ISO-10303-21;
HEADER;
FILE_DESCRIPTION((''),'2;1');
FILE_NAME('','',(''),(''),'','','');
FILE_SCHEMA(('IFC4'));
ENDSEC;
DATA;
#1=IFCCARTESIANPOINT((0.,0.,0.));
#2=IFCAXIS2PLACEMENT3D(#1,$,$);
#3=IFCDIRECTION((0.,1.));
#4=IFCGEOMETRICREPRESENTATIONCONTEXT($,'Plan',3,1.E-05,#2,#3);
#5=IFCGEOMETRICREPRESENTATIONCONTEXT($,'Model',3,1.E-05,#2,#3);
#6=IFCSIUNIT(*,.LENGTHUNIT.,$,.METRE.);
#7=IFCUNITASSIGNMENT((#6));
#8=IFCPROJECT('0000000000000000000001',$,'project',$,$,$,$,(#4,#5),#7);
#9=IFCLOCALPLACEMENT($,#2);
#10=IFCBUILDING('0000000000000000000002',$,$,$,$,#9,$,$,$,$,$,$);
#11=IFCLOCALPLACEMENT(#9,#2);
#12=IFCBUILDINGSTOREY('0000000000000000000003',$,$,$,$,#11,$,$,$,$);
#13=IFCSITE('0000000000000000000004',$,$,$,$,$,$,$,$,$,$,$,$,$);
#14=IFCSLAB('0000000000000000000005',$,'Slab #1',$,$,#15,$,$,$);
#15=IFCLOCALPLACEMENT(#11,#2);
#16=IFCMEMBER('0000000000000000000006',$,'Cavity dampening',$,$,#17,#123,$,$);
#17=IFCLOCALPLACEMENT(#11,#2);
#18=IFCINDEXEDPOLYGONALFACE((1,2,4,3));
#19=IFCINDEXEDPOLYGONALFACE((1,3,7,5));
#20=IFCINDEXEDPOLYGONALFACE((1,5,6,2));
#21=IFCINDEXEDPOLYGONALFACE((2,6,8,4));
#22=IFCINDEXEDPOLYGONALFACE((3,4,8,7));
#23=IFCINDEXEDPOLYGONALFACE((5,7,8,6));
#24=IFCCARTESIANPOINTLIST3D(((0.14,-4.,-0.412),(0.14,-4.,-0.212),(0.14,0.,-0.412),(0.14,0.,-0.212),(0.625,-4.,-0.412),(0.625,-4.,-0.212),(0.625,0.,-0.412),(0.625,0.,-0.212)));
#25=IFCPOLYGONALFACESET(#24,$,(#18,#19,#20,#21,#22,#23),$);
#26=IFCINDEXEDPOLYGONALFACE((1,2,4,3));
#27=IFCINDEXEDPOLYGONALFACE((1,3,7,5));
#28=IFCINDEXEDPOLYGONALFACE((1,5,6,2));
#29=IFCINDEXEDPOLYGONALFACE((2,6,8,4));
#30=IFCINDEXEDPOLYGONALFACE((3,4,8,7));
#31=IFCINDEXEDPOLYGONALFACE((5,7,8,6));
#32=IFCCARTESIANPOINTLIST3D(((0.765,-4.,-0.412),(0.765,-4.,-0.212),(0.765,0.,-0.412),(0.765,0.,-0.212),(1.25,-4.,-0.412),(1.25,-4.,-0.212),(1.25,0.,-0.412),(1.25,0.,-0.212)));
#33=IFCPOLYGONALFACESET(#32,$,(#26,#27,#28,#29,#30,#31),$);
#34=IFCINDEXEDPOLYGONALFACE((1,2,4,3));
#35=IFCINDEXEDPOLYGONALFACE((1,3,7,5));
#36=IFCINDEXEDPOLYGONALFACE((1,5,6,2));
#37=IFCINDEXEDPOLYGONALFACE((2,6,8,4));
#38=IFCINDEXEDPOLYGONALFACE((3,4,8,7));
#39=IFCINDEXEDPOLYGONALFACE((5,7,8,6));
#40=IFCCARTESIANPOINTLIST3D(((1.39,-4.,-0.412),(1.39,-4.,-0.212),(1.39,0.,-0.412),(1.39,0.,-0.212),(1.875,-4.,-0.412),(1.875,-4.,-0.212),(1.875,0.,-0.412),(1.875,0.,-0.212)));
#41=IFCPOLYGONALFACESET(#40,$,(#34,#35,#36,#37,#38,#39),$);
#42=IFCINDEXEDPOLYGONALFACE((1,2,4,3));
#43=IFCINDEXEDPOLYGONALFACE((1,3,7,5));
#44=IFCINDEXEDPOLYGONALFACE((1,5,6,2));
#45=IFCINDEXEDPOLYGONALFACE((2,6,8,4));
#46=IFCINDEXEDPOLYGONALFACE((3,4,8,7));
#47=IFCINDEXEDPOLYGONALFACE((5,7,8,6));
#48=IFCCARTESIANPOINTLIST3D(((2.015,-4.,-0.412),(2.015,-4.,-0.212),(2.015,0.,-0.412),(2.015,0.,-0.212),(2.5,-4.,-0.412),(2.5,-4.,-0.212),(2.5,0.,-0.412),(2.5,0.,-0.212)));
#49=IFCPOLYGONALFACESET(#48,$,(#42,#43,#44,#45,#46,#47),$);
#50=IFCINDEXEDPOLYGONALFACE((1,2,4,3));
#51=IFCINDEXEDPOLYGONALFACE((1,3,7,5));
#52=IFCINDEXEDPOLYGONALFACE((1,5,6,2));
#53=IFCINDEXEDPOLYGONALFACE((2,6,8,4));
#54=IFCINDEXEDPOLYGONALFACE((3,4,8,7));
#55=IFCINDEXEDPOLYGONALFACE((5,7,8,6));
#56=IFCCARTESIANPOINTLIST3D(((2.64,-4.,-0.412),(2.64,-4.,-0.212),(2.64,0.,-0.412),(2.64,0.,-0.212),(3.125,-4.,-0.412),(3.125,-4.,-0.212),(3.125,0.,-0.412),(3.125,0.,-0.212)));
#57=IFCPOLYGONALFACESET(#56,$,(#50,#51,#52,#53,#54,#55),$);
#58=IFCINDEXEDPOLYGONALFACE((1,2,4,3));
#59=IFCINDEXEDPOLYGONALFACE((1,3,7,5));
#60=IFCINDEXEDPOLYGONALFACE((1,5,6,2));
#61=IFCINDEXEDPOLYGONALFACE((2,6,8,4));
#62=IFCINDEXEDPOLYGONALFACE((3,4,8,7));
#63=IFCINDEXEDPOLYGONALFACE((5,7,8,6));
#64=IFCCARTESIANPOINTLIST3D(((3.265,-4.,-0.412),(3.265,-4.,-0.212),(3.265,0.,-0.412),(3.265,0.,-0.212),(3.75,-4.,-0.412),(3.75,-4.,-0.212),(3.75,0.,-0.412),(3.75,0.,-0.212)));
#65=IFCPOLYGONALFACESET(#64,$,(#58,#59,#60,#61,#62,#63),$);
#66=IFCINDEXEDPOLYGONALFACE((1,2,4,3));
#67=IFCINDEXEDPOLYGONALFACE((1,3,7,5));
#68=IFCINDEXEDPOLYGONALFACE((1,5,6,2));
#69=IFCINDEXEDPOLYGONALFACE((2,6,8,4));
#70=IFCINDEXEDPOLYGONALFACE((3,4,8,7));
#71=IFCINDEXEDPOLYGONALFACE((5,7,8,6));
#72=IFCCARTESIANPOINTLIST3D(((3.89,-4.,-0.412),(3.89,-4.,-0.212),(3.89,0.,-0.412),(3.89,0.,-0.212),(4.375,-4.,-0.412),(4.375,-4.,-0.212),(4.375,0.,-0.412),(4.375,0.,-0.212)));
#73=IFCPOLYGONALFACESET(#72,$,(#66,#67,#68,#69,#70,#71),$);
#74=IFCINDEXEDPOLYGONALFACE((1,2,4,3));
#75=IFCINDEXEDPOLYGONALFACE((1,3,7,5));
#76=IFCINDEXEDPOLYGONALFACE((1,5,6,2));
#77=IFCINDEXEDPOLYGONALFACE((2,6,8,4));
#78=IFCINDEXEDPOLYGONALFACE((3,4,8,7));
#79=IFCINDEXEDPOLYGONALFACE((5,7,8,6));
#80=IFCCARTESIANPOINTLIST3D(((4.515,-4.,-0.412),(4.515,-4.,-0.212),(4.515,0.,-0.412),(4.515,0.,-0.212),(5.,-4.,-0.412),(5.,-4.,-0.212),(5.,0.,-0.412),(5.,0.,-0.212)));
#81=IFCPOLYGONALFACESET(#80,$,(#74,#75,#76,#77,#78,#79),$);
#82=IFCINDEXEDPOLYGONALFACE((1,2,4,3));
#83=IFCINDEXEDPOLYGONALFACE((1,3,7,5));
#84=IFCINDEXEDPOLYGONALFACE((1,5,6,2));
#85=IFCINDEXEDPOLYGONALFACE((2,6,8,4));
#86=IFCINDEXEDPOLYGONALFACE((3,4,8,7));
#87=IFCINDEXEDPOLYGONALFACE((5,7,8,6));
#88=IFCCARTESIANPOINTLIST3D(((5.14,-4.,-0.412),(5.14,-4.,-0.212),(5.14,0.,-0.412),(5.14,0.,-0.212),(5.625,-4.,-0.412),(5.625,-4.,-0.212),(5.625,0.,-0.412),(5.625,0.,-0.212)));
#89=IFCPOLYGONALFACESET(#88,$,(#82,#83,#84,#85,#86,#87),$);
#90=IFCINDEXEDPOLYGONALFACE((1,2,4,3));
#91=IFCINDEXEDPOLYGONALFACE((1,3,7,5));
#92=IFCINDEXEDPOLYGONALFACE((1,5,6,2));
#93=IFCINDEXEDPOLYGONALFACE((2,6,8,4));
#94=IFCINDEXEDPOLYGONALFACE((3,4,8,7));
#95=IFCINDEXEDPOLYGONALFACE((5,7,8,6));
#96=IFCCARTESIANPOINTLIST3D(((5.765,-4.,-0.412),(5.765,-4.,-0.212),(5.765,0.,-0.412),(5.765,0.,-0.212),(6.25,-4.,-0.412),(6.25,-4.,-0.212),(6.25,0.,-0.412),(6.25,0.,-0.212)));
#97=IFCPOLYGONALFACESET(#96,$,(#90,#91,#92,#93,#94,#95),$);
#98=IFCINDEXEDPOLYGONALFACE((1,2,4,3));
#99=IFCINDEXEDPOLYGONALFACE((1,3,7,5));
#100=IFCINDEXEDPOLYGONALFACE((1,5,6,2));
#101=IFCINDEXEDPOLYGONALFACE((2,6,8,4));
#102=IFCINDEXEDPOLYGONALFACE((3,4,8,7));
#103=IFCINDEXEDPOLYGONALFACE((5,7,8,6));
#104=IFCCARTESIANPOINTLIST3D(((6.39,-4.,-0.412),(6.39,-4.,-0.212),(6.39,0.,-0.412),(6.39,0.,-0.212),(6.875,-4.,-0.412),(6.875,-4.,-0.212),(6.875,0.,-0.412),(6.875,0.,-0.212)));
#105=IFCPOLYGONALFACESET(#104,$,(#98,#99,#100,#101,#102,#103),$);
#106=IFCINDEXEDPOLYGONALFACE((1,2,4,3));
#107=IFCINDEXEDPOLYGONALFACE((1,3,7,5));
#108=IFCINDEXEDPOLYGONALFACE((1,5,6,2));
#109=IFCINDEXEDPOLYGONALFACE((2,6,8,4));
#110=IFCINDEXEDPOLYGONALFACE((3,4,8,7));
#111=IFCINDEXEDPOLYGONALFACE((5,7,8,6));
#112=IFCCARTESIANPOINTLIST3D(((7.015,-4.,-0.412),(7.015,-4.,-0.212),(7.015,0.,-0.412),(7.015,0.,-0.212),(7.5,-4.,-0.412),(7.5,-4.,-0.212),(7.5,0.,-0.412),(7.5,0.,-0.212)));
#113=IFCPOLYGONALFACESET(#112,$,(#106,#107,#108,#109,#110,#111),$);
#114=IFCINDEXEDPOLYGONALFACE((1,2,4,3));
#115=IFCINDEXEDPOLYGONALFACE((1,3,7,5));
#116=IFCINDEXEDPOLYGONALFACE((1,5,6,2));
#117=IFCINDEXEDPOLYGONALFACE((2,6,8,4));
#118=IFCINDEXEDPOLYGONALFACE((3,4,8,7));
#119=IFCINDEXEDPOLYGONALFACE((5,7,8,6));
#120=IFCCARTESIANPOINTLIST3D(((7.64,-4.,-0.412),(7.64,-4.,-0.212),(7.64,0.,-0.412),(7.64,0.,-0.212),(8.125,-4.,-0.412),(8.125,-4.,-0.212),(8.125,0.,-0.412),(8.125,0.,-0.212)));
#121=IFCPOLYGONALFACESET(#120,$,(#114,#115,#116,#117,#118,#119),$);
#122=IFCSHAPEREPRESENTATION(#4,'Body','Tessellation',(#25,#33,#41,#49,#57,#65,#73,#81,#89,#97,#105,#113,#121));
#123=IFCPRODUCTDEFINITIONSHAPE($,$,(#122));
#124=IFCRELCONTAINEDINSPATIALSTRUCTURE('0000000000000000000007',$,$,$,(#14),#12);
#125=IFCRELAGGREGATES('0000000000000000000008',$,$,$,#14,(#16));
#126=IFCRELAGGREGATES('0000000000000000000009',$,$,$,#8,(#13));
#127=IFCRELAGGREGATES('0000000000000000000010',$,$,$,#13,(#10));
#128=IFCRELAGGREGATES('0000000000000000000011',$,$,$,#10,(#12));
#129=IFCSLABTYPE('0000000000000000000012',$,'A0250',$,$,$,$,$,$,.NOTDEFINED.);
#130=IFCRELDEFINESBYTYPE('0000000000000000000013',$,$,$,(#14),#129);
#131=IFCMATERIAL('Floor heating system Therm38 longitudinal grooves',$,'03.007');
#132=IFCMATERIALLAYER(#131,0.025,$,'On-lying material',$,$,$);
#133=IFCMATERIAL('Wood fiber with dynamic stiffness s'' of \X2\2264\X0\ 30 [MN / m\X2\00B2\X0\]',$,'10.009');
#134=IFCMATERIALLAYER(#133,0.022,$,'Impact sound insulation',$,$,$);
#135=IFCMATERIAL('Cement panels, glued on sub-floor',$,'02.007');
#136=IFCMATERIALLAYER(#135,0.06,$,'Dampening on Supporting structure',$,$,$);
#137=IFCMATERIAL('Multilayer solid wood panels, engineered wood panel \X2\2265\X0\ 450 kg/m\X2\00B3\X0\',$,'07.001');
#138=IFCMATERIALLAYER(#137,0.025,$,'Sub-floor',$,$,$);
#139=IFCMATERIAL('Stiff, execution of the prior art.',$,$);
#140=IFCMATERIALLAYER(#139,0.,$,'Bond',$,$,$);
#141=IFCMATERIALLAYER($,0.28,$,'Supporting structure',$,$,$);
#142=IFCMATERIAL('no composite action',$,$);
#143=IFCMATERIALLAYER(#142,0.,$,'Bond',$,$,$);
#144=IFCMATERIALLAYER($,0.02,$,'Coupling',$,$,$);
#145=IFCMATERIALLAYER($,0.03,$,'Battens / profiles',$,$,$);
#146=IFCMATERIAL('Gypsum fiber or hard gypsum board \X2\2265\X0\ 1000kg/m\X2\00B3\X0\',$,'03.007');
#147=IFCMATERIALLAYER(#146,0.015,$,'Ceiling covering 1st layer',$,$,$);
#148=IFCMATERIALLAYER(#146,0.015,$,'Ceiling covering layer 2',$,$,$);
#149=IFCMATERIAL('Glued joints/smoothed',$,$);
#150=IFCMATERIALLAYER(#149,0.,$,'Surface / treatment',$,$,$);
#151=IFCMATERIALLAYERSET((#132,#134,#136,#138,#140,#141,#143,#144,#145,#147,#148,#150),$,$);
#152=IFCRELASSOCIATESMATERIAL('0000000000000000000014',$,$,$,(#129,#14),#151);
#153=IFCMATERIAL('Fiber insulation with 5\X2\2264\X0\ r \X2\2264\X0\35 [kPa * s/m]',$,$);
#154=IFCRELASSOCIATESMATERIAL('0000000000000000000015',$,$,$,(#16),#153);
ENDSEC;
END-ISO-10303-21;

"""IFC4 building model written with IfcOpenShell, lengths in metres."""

from ifc_helpers import new_model, si_unit, direction, frame, frame_2d, origin, place, context, project, spatial, rectangle, extrude, material, layer, layer_set, type_object, element, aggregate, save


model = new_model("IFC4")

# Units and contexts
plan_context = context("Plan", 3, precision=1e-05, world=origin(), true_north=direction((0.0, 1.0)))
model_context = context("Model", 3, precision=1e-05, world=origin(), true_north=direction((0.0, 1.0)))
ifc_project = project(units=[si_unit("LENGTHUNIT", "METRE")], contexts=[plan_context, model_context])

# Site, building, storey
site = spatial("IfcSite", under=ifc_project)
building_placement = place(None, origin())
building = spatial("IfcBuilding", under=site, at=building_placement)
storey_placement = place(building_placement, origin())
storey = spatial("IfcBuildingStorey", under=building, at=storey_placement)

# Slab, member
ifc_material_1 = material(Name="Floor heating system Therm38 longitudinal grooves", Category="03.007")
ifc_layer_1 = layer(ifc_material_1, 0.025, Name="On-lying material")
ifc_material_2 = material(Name="Wood fiber with dynamic stiffness s' of ≤ 30 [MN / m²]", Category="10.009")
ifc_layer_2 = layer(ifc_material_2, 0.022, Name="Impact sound insulation")
ifc_material_3 = material(Name="Cement panels, glued on sub-floor", Category="02.007")
ifc_layer_3 = layer(ifc_material_3, 0.06, Name="Dampening on Supporting structure")
ifc_material_4 = material(Name="Multilayer solid wood panels, engineered wood panel ≥ 450 kg/m³", Category="07.001")
ifc_layer_4 = layer(ifc_material_4, 0.025, Name="Sub-floor")
ifc_material_5 = material(Name="Stiff, execution of the prior art.")
ifc_layer_5 = layer(ifc_material_5, 0.0, Name="Bond")
ifc_layer_6 = layer(None, 0.28, Name="Supporting structure")
ifc_material_6 = material(Name="no composite action")
ifc_layer_7 = layer(ifc_material_6, 0.0, Name="Bond")
ifc_layer_8 = layer(None, 0.02, Name="Coupling")
ifc_layer_9 = layer(None, 0.03, Name="Battens / profiles")
ifc_material_7 = material(Name="Gypsum fiber or hard gypsum board ≥ 1000kg/m³", Category="03.007")
ifc_layer_10 = layer(ifc_material_7, 0.015, Name="Ceiling covering 1st layer")
ifc_layer_11 = layer(ifc_material_7, 0.015, Name="Ceiling covering layer 2")
ifc_material_8 = material(Name="Glued joints/smoothed")
ifc_layer_12 = layer(ifc_material_8, 0.0, Name="Surface / treatment")
ifc_layer_set = layer_set([ifc_layer_1, ifc_layer_2, ifc_layer_3, ifc_layer_4, ifc_layer_5, ifc_layer_6, ifc_layer_7, ifc_layer_8, ifc_layer_9, ifc_layer_10, ifc_layer_11, ifc_layer_12])
slab_type = type_object("IfcSlabType", Name="A0250", PredefinedType="NOTDEFINED", material=ifc_layer_set)
slab_placement = place(None, frame((0.0, 0.0, 0.0), z_axis=(0.0, 0.0, -1.0), x_axis=(1.0, 0.0, 0.0)))
slab = element("IfcSlab", 1, at=slab_placement, inside=storey, type_object=slab_type, material=ifc_layer_set, Name="Slab #1")
ifc_material_9 = material(Name="Fiber insulation with 5≤ r ≤35 [kPa * s/m]")
member_1_placement = place(slab_placement, origin())
member_1 = element("IfcMember", 2, at=member_1_placement, material=ifc_material_9, Name="Cavity dampening", context=plan_context, shape_type="SweptSolid", body=[
    extrude(rectangle(XDim=0.485, YDim=0.2, at=frame_2d((0.2425, 0.1), x_axis=(1.0, 0.0))), frame((0.14, 4.0, 0.212), z_axis=(0.0, -1.0, 0.0), x_axis=(1.0, 0.0, 0.0)), (0.0, 0.0, 1.0), 4.0),
    extrude(rectangle(XDim=0.485, YDim=0.2, at=frame_2d((0.2425, 0.1), x_axis=(1.0, 0.0))), frame((0.765, 4.0, 0.212), z_axis=(0.0, -1.0, 0.0), x_axis=(1.0, 0.0, 0.0)), (0.0, 0.0, 1.0), 4.0),
    extrude(rectangle(XDim=0.485, YDim=0.2, at=frame_2d((0.2425, 0.1), x_axis=(1.0, 0.0))), frame((1.39, 4.0, 0.212), z_axis=(0.0, -1.0, 0.0), x_axis=(1.0, 0.0, 0.0)), (0.0, 0.0, 1.0), 4.0),
    extrude(rectangle(XDim=0.485, YDim=0.2, at=frame_2d((0.2425, 0.1), x_axis=(1.0, 0.0))), frame((2.015, 4.0, 0.212), z_axis=(0.0, -1.0, 0.0), x_axis=(1.0, 0.0, 0.0)), (0.0, 0.0, 1.0), 4.0),
    extrude(rectangle(XDim=0.485, YDim=0.2, at=frame_2d((0.2425, 0.1), x_axis=(1.0, 0.0))), frame((2.64, 4.0, 0.212), z_axis=(0.0, -1.0, 0.0), x_axis=(1.0, 0.0, 0.0)), (0.0, 0.0, 1.0), 4.0),
    extrude(rectangle(XDim=0.485, YDim=0.2, at=frame_2d((0.2425, 0.1), x_axis=(1.0, 0.0))), frame((3.265, 4.0, 0.212), z_axis=(0.0, -1.0, 0.0), x_axis=(1.0, 0.0, 0.0)), (0.0, 0.0, 1.0), 4.0),
    extrude(rectangle(XDim=0.485, YDim=0.2, at=frame_2d((0.2425, 0.1), x_axis=(1.0, 0.0))), frame((3.89, 4.0, 0.212), z_axis=(0.0, -1.0, 0.0), x_axis=(1.0, 0.0, 0.0)), (0.0, 0.0, 1.0), 4.0),
    extrude(rectangle(XDim=0.485, YDim=0.2, at=frame_2d((0.2425, 0.1), x_axis=(1.0, 0.0))), frame((4.515, 4.0, 0.212), z_axis=(0.0, -1.0, 0.0), x_axis=(1.0, 0.0, 0.0)), (0.0, 0.0, 1.0), 4.0),
    extrude(rectangle(XDim=0.485, YDim=0.2, at=frame_2d((0.2425, 0.1), x_axis=(1.0, 0.0))), frame((5.14, 4.0, 0.212), z_axis=(0.0, -1.0, 0.0), x_axis=(1.0, 0.0, 0.0)), (0.0, 0.0, 1.0), 4.0),
    extrude(rectangle(XDim=0.485, YDim=0.2, at=frame_2d((0.2425, 0.1), x_axis=(1.0, 0.0))), frame((5.765, 4.0, 0.212), z_axis=(0.0, -1.0, 0.0), x_axis=(1.0, 0.0, 0.0)), (0.0, 0.0, 1.0), 4.0),
    extrude(rectangle(XDim=0.485, YDim=0.2, at=frame_2d((0.2425, 0.1), x_axis=(1.0, 0.0))), frame((6.39, 4.0, 0.212), z_axis=(0.0, -1.0, 0.0), x_axis=(1.0, 0.0, 0.0)), (0.0, 0.0, 1.0), 4.0),
    extrude(rectangle(XDim=0.485, YDim=0.2, at=frame_2d((0.2425, 0.1), x_axis=(1.0, 0.0))), frame((7.015, 4.0, 0.212), z_axis=(0.0, -1.0, 0.0), x_axis=(1.0, 0.0, 0.0)), (0.0, 0.0, 1.0), 4.0),
    extrude(rectangle(XDim=0.485, YDim=0.2, at=frame_2d((0.2425, 0.1), x_axis=(1.0, 0.0))), frame((7.64, 4.0, 0.212), z_axis=(0.0, -1.0, 0.0), x_axis=(1.0, 0.0, 0.0)), (0.0, 0.0, 1.0), 4.0),
])
aggregate(slab, [member_1])

save(model, "model.ifc")
